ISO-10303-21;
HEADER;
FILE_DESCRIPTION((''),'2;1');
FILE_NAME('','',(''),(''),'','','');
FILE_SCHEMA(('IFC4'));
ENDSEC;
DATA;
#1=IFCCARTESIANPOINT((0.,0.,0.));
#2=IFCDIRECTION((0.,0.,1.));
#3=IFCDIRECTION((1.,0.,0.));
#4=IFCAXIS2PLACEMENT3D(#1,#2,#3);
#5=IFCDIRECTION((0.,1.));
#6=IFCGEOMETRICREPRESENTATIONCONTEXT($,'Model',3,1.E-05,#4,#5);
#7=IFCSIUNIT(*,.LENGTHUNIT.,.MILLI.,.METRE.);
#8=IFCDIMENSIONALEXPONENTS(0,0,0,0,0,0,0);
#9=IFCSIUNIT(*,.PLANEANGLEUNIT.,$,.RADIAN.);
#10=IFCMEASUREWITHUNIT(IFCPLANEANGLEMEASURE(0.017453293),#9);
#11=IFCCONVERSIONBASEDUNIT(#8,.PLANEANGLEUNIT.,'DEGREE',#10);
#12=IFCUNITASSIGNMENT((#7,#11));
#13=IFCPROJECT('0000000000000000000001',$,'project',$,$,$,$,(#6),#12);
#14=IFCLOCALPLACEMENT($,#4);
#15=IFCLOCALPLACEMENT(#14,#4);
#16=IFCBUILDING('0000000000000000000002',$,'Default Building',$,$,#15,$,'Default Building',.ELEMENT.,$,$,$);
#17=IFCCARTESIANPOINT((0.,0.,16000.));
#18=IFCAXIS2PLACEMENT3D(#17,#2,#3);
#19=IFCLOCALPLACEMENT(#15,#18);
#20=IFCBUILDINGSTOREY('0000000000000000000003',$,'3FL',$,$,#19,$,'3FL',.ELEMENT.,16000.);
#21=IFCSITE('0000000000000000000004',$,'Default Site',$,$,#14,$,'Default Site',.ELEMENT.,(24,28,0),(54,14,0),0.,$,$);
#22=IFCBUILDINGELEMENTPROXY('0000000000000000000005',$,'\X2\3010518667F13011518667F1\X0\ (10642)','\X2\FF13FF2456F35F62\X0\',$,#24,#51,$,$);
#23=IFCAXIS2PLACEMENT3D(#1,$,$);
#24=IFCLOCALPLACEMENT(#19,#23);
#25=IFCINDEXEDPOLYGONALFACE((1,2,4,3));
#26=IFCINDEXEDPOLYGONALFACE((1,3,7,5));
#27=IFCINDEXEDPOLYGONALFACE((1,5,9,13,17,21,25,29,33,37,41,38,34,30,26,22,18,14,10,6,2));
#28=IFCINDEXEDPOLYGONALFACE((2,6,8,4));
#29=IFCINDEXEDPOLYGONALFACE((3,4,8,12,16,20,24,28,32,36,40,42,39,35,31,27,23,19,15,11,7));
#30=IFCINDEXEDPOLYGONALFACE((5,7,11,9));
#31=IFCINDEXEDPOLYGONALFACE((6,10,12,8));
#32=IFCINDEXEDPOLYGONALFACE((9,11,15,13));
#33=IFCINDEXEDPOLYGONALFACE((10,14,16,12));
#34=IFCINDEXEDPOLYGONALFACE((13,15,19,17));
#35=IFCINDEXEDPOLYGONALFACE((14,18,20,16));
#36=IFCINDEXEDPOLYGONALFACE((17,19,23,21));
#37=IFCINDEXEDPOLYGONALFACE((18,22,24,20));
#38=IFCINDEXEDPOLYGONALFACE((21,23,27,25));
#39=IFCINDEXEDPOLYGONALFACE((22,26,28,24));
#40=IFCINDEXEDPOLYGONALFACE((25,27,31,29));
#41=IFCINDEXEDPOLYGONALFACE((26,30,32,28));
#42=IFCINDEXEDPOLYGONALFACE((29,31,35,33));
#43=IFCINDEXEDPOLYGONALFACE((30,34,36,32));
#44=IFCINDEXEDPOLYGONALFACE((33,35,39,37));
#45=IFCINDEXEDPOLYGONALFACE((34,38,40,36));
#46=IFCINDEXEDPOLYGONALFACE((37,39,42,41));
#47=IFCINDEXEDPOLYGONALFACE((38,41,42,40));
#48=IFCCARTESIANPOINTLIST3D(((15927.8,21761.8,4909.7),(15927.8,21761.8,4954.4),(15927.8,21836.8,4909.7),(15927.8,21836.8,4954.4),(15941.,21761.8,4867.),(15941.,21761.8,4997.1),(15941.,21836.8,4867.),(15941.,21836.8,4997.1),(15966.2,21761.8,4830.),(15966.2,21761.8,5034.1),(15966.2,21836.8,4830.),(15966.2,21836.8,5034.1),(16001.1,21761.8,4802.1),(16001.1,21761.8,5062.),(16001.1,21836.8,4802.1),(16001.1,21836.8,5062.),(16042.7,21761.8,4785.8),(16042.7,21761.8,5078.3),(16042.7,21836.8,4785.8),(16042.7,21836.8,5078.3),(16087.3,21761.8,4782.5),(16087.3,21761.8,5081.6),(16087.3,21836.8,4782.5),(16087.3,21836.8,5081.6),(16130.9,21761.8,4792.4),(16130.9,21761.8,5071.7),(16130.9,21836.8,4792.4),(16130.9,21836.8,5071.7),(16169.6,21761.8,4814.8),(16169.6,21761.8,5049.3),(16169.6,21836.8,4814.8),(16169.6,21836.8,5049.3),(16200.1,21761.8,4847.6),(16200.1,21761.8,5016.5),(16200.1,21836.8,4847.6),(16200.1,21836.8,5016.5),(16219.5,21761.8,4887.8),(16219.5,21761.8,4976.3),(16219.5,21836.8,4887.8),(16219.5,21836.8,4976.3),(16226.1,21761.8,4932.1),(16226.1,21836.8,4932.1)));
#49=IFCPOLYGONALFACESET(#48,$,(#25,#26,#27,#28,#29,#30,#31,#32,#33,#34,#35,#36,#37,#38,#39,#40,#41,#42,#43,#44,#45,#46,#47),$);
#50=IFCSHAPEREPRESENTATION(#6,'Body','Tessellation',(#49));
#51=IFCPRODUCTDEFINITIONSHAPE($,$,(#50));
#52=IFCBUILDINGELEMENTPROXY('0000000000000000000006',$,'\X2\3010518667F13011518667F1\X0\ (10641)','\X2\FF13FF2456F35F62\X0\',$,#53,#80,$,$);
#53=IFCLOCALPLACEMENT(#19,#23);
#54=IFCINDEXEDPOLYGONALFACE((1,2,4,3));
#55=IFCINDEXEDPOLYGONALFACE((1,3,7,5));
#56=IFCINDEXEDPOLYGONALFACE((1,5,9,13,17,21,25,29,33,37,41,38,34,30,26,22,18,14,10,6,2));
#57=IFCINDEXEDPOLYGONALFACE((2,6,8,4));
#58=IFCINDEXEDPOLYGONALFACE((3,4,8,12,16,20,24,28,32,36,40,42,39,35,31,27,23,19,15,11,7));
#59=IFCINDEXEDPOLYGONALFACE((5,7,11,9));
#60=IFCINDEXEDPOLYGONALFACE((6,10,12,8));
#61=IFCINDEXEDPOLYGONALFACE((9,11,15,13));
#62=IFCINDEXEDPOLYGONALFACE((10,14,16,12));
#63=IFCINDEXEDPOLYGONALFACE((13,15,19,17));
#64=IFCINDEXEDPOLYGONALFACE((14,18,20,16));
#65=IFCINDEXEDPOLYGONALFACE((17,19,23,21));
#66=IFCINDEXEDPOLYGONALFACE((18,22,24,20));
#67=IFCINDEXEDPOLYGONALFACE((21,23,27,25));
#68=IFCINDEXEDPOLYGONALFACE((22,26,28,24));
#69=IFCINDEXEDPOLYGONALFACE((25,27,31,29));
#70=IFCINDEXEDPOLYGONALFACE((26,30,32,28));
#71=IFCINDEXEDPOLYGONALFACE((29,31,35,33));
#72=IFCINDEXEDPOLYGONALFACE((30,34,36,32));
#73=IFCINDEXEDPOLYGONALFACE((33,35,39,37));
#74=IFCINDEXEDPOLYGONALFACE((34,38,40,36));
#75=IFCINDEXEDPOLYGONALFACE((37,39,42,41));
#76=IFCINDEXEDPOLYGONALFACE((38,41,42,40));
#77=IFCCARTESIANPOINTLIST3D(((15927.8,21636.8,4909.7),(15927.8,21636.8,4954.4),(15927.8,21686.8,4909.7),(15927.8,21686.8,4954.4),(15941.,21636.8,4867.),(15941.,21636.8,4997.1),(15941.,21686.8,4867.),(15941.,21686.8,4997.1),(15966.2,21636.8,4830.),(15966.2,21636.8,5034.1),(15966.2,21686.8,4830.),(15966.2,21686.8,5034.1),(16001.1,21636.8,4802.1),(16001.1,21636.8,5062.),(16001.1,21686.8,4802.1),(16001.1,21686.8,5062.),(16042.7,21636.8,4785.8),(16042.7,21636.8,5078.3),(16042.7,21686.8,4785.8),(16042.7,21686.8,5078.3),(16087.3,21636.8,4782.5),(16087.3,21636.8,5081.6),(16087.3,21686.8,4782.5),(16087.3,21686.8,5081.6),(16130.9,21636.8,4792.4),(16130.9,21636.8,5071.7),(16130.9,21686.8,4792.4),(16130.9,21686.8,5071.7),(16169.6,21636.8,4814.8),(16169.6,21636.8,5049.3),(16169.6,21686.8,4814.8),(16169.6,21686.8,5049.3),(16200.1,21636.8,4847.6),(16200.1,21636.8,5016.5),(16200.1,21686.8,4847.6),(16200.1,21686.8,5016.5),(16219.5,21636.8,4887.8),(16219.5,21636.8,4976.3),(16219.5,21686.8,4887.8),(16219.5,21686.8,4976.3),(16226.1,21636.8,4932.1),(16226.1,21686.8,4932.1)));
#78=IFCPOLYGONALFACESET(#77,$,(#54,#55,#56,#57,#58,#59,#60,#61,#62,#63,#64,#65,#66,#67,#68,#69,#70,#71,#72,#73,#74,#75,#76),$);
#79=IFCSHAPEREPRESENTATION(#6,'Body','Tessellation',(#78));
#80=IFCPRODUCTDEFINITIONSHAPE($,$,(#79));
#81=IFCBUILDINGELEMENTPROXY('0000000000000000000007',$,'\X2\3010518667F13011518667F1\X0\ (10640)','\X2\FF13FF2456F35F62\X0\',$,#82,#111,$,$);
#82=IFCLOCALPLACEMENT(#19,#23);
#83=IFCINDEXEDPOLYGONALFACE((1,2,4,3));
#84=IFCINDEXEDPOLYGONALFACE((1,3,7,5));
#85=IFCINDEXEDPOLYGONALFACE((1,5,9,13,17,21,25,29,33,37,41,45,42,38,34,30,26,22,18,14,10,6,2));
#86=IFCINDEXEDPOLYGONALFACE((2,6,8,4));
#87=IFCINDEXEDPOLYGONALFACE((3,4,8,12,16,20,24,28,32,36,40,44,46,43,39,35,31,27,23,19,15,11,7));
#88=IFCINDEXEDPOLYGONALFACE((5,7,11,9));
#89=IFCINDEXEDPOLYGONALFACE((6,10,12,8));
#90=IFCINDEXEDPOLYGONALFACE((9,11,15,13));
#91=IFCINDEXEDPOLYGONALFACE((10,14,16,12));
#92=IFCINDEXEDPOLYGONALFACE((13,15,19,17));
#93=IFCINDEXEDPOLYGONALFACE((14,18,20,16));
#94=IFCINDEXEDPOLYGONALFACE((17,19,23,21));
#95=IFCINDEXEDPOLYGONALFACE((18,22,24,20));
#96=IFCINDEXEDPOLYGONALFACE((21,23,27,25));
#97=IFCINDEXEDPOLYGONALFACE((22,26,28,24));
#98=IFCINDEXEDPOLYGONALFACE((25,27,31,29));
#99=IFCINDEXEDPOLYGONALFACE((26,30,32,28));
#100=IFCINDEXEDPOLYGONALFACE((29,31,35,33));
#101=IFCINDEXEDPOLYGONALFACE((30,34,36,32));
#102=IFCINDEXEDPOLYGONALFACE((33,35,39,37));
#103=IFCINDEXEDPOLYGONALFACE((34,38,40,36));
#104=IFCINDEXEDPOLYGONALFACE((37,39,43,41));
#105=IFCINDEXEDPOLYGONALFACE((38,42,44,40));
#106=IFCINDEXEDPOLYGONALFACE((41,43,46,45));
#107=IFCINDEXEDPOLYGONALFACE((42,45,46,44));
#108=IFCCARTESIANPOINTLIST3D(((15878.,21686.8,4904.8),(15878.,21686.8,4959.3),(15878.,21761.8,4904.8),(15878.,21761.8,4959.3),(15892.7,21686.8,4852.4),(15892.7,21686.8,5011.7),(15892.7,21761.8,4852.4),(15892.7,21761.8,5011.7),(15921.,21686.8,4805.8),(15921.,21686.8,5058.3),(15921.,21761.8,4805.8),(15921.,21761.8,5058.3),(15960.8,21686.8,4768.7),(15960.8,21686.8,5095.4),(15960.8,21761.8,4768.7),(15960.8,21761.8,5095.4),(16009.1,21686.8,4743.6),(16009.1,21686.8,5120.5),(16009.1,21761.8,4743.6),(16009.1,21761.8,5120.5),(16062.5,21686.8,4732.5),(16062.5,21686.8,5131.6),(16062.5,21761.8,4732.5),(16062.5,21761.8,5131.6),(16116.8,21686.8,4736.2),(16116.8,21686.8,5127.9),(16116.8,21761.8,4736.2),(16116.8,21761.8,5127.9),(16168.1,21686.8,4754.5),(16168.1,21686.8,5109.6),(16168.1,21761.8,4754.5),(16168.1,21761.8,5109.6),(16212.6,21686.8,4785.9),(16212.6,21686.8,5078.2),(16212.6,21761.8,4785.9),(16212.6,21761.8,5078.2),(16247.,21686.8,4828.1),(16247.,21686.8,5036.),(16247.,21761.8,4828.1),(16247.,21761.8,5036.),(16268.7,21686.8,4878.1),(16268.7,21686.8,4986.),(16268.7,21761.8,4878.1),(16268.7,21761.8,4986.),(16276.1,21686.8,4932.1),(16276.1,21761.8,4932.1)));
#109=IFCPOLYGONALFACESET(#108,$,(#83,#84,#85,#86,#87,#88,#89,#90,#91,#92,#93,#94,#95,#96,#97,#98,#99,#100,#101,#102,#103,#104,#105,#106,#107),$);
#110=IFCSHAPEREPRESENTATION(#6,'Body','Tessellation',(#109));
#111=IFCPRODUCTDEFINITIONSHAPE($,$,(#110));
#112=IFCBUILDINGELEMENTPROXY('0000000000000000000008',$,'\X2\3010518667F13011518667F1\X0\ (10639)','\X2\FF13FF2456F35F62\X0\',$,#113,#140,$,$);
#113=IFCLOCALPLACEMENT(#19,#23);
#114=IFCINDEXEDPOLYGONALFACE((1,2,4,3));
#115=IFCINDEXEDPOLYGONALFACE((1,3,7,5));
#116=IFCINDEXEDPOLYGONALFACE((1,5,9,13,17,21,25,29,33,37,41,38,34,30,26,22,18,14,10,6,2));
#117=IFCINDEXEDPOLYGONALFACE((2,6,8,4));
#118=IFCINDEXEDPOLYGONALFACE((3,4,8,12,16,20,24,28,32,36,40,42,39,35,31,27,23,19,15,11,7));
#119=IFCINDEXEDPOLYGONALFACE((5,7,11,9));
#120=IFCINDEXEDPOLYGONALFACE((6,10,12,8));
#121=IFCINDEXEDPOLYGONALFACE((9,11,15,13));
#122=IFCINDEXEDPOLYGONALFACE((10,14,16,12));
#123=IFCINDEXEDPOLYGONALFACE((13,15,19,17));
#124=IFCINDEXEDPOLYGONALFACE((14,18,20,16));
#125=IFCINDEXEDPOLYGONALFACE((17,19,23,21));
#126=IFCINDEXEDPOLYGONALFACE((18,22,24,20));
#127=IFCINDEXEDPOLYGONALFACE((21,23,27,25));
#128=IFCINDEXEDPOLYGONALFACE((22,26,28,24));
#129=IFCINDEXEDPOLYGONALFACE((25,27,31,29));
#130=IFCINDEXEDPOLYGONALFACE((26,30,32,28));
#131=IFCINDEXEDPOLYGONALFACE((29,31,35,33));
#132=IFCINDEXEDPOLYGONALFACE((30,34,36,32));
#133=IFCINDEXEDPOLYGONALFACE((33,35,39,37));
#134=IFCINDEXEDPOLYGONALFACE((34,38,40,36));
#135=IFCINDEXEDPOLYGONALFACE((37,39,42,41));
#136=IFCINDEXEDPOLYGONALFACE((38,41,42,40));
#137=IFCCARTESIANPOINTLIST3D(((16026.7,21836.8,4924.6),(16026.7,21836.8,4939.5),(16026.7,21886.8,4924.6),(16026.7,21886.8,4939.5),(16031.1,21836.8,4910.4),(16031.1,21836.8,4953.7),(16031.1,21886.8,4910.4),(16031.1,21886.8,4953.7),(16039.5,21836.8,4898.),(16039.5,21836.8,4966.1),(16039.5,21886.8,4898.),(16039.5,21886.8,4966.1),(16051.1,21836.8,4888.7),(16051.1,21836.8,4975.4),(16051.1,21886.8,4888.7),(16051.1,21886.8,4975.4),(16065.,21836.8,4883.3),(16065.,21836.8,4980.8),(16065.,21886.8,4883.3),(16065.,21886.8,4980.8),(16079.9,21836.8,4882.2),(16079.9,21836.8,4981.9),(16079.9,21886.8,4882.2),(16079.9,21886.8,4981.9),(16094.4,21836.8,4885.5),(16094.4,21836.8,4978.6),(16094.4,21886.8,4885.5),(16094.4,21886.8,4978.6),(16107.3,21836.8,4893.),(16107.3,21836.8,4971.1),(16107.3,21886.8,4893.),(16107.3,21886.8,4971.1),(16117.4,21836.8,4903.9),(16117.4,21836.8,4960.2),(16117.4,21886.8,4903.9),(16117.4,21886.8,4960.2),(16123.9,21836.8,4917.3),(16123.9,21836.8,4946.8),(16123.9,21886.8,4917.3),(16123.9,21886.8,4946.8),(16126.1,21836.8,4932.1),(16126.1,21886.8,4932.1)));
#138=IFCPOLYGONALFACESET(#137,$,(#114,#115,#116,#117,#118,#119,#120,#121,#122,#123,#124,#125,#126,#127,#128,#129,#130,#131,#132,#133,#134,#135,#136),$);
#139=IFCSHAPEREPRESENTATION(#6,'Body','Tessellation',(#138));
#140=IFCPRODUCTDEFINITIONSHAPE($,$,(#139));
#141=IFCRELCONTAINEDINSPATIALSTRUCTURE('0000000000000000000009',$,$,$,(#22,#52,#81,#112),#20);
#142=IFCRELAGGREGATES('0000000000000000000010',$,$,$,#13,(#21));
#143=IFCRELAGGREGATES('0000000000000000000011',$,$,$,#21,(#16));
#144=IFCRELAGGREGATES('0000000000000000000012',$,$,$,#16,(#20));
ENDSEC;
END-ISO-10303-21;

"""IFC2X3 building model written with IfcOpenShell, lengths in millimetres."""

from ifc_helpers import new_model, entity, si_unit, converted_unit, direction, frame, origin_with_axes, origin_2d_with_axis, place, context, project, spatial, circle, extrude, source, transform, mapped, element, save


model = new_model("IFC2X3")

# Units and contexts
model_context = context("Model", 3, precision=1e-05, world=origin_with_axes(), true_north=direction((0.0, 1.0)))
ifc_project = project(units=[si_unit("LENGTHUNIT", "METRE", prefix="MILLI"), converted_unit("PLANEANGLEUNIT", "DEGREE", entity("IfcPlaneAngleMeasure", 0.017453293), si_unit("PLANEANGLEUNIT", "RADIAN"), dimensions=[0, 0, 0, 0, 0, 0, 0])], contexts=[model_context])

# Site, building, storey
site_placement = place(None, origin_with_axes())
site = spatial("IfcSite", under=ifc_project, at=site_placement, Name="Default Site", LongName="Default Site", CompositionType="ELEMENT", RefLatitude=(24, 28, 0), RefLongitude=(54, 14, 0), RefElevation=0.0)
building_placement = place(site_placement, origin_with_axes())
building = spatial("IfcBuilding", under=site, at=building_placement, Name="Default Building", LongName="Default Building", CompositionType="ELEMENT")
storey_placement = place(building_placement, frame((0.0, 0.0, 16000.0), z_axis=(0.0, 0.0, 1.0), x_axis=(1.0, 0.0, 0.0)))
storey = spatial("IfcBuildingStorey", under=building, at=storey_placement, Name="3FL", LongName="3FL", CompositionType="ELEMENT", Elevation=16000.0)

# Building element proxies
shared_shape_1 = source(origin_with_axes(), model_context, "Body", "SweptSolid", [
    extrude(circle(Radius=150.0, at=origin_2d_with_axis()), frame((0.0, 0.0, 0.0), z_axis=(0.0, 0.0, 1.0), x_axis=(1.0, 0.0, 0.0)), (0.0, 0.0, 1.0), 75.0),
])
proxy_1_placement = place(storey_placement, frame((16076.1, 21761.8, 4932.1), z_axis=(0.0, 1.0, 0.0), x_axis=(1.0, 0.0, 0.0)))
element("IfcBuildingElementProxy", 1, at=proxy_1_placement, inside=storey, Name="【円柱】円柱 (10642)", Description="３Ｄ図形", context=model_context, shape_type="MappedRepresentation", body=[
    mapped(shared_shape_1, transform((0.0, 0.0, 0.0))),
])
shared_shape_2 = source(origin_with_axes(), model_context, "Body", "SweptSolid", [
    extrude(circle(Radius=150.0, at=origin_2d_with_axis()), frame((0.0, 0.0, 0.0), z_axis=(0.0, 0.0, 1.0), x_axis=(1.0, 0.0, 0.0)), (0.0, 0.0, 1.0), 50.0),
])
proxy_2_placement = place(storey_placement, frame((16076.1, 21636.8, 4932.1), z_axis=(0.0, 1.0, 0.0), x_axis=(1.0, 0.0, 0.0)))
element("IfcBuildingElementProxy", 2, at=proxy_2_placement, inside=storey, Name="【円柱】円柱 (10641)", Description="３Ｄ図形", context=model_context, shape_type="MappedRepresentation", body=[
    mapped(shared_shape_2, transform((0.0, 0.0, 0.0))),
])
shared_shape_3 = source(origin_with_axes(), model_context, "Body", "SweptSolid", [
    extrude(circle(Radius=200.0, at=origin_2d_with_axis()), frame((0.0, 0.0, 0.0), z_axis=(0.0, 0.0, 1.0), x_axis=(1.0, 0.0, 0.0)), (0.0, 0.0, 1.0), 75.0),
])
proxy_3_placement = place(storey_placement, frame((16076.1, 21686.8, 4932.1), z_axis=(0.0, 1.0, 0.0), x_axis=(1.0, 0.0, 0.0)))
element("IfcBuildingElementProxy", 3, at=proxy_3_placement, inside=storey, Name="【円柱】円柱 (10640)", Description="３Ｄ図形", context=model_context, shape_type="MappedRepresentation", body=[
    mapped(shared_shape_3, transform((0.0, 0.0, 0.0))),
])
shared_shape_4 = source(origin_with_axes(), model_context, "Body", "SweptSolid", [
    extrude(circle(Radius=50.0, at=origin_2d_with_axis()), frame((0.0, 0.0, 0.0), z_axis=(0.0, 0.0, 1.0), x_axis=(1.0, 0.0, 0.0)), (0.0, 0.0, 1.0), 50.0),
])
proxy_4_placement = place(storey_placement, frame((16076.1, 21836.8, 4932.1), z_axis=(0.0, 1.0, 0.0), x_axis=(1.0, 0.0, 0.0)))
element("IfcBuildingElementProxy", 4, at=proxy_4_placement, inside=storey, Name="【円柱】円柱 (10639)", Description="３Ｄ図形", context=model_context, shape_type="MappedRepresentation", body=[
    mapped(shared_shape_4, transform((0.0, 0.0, 0.0))),
])

save(model, "model.ifc")
